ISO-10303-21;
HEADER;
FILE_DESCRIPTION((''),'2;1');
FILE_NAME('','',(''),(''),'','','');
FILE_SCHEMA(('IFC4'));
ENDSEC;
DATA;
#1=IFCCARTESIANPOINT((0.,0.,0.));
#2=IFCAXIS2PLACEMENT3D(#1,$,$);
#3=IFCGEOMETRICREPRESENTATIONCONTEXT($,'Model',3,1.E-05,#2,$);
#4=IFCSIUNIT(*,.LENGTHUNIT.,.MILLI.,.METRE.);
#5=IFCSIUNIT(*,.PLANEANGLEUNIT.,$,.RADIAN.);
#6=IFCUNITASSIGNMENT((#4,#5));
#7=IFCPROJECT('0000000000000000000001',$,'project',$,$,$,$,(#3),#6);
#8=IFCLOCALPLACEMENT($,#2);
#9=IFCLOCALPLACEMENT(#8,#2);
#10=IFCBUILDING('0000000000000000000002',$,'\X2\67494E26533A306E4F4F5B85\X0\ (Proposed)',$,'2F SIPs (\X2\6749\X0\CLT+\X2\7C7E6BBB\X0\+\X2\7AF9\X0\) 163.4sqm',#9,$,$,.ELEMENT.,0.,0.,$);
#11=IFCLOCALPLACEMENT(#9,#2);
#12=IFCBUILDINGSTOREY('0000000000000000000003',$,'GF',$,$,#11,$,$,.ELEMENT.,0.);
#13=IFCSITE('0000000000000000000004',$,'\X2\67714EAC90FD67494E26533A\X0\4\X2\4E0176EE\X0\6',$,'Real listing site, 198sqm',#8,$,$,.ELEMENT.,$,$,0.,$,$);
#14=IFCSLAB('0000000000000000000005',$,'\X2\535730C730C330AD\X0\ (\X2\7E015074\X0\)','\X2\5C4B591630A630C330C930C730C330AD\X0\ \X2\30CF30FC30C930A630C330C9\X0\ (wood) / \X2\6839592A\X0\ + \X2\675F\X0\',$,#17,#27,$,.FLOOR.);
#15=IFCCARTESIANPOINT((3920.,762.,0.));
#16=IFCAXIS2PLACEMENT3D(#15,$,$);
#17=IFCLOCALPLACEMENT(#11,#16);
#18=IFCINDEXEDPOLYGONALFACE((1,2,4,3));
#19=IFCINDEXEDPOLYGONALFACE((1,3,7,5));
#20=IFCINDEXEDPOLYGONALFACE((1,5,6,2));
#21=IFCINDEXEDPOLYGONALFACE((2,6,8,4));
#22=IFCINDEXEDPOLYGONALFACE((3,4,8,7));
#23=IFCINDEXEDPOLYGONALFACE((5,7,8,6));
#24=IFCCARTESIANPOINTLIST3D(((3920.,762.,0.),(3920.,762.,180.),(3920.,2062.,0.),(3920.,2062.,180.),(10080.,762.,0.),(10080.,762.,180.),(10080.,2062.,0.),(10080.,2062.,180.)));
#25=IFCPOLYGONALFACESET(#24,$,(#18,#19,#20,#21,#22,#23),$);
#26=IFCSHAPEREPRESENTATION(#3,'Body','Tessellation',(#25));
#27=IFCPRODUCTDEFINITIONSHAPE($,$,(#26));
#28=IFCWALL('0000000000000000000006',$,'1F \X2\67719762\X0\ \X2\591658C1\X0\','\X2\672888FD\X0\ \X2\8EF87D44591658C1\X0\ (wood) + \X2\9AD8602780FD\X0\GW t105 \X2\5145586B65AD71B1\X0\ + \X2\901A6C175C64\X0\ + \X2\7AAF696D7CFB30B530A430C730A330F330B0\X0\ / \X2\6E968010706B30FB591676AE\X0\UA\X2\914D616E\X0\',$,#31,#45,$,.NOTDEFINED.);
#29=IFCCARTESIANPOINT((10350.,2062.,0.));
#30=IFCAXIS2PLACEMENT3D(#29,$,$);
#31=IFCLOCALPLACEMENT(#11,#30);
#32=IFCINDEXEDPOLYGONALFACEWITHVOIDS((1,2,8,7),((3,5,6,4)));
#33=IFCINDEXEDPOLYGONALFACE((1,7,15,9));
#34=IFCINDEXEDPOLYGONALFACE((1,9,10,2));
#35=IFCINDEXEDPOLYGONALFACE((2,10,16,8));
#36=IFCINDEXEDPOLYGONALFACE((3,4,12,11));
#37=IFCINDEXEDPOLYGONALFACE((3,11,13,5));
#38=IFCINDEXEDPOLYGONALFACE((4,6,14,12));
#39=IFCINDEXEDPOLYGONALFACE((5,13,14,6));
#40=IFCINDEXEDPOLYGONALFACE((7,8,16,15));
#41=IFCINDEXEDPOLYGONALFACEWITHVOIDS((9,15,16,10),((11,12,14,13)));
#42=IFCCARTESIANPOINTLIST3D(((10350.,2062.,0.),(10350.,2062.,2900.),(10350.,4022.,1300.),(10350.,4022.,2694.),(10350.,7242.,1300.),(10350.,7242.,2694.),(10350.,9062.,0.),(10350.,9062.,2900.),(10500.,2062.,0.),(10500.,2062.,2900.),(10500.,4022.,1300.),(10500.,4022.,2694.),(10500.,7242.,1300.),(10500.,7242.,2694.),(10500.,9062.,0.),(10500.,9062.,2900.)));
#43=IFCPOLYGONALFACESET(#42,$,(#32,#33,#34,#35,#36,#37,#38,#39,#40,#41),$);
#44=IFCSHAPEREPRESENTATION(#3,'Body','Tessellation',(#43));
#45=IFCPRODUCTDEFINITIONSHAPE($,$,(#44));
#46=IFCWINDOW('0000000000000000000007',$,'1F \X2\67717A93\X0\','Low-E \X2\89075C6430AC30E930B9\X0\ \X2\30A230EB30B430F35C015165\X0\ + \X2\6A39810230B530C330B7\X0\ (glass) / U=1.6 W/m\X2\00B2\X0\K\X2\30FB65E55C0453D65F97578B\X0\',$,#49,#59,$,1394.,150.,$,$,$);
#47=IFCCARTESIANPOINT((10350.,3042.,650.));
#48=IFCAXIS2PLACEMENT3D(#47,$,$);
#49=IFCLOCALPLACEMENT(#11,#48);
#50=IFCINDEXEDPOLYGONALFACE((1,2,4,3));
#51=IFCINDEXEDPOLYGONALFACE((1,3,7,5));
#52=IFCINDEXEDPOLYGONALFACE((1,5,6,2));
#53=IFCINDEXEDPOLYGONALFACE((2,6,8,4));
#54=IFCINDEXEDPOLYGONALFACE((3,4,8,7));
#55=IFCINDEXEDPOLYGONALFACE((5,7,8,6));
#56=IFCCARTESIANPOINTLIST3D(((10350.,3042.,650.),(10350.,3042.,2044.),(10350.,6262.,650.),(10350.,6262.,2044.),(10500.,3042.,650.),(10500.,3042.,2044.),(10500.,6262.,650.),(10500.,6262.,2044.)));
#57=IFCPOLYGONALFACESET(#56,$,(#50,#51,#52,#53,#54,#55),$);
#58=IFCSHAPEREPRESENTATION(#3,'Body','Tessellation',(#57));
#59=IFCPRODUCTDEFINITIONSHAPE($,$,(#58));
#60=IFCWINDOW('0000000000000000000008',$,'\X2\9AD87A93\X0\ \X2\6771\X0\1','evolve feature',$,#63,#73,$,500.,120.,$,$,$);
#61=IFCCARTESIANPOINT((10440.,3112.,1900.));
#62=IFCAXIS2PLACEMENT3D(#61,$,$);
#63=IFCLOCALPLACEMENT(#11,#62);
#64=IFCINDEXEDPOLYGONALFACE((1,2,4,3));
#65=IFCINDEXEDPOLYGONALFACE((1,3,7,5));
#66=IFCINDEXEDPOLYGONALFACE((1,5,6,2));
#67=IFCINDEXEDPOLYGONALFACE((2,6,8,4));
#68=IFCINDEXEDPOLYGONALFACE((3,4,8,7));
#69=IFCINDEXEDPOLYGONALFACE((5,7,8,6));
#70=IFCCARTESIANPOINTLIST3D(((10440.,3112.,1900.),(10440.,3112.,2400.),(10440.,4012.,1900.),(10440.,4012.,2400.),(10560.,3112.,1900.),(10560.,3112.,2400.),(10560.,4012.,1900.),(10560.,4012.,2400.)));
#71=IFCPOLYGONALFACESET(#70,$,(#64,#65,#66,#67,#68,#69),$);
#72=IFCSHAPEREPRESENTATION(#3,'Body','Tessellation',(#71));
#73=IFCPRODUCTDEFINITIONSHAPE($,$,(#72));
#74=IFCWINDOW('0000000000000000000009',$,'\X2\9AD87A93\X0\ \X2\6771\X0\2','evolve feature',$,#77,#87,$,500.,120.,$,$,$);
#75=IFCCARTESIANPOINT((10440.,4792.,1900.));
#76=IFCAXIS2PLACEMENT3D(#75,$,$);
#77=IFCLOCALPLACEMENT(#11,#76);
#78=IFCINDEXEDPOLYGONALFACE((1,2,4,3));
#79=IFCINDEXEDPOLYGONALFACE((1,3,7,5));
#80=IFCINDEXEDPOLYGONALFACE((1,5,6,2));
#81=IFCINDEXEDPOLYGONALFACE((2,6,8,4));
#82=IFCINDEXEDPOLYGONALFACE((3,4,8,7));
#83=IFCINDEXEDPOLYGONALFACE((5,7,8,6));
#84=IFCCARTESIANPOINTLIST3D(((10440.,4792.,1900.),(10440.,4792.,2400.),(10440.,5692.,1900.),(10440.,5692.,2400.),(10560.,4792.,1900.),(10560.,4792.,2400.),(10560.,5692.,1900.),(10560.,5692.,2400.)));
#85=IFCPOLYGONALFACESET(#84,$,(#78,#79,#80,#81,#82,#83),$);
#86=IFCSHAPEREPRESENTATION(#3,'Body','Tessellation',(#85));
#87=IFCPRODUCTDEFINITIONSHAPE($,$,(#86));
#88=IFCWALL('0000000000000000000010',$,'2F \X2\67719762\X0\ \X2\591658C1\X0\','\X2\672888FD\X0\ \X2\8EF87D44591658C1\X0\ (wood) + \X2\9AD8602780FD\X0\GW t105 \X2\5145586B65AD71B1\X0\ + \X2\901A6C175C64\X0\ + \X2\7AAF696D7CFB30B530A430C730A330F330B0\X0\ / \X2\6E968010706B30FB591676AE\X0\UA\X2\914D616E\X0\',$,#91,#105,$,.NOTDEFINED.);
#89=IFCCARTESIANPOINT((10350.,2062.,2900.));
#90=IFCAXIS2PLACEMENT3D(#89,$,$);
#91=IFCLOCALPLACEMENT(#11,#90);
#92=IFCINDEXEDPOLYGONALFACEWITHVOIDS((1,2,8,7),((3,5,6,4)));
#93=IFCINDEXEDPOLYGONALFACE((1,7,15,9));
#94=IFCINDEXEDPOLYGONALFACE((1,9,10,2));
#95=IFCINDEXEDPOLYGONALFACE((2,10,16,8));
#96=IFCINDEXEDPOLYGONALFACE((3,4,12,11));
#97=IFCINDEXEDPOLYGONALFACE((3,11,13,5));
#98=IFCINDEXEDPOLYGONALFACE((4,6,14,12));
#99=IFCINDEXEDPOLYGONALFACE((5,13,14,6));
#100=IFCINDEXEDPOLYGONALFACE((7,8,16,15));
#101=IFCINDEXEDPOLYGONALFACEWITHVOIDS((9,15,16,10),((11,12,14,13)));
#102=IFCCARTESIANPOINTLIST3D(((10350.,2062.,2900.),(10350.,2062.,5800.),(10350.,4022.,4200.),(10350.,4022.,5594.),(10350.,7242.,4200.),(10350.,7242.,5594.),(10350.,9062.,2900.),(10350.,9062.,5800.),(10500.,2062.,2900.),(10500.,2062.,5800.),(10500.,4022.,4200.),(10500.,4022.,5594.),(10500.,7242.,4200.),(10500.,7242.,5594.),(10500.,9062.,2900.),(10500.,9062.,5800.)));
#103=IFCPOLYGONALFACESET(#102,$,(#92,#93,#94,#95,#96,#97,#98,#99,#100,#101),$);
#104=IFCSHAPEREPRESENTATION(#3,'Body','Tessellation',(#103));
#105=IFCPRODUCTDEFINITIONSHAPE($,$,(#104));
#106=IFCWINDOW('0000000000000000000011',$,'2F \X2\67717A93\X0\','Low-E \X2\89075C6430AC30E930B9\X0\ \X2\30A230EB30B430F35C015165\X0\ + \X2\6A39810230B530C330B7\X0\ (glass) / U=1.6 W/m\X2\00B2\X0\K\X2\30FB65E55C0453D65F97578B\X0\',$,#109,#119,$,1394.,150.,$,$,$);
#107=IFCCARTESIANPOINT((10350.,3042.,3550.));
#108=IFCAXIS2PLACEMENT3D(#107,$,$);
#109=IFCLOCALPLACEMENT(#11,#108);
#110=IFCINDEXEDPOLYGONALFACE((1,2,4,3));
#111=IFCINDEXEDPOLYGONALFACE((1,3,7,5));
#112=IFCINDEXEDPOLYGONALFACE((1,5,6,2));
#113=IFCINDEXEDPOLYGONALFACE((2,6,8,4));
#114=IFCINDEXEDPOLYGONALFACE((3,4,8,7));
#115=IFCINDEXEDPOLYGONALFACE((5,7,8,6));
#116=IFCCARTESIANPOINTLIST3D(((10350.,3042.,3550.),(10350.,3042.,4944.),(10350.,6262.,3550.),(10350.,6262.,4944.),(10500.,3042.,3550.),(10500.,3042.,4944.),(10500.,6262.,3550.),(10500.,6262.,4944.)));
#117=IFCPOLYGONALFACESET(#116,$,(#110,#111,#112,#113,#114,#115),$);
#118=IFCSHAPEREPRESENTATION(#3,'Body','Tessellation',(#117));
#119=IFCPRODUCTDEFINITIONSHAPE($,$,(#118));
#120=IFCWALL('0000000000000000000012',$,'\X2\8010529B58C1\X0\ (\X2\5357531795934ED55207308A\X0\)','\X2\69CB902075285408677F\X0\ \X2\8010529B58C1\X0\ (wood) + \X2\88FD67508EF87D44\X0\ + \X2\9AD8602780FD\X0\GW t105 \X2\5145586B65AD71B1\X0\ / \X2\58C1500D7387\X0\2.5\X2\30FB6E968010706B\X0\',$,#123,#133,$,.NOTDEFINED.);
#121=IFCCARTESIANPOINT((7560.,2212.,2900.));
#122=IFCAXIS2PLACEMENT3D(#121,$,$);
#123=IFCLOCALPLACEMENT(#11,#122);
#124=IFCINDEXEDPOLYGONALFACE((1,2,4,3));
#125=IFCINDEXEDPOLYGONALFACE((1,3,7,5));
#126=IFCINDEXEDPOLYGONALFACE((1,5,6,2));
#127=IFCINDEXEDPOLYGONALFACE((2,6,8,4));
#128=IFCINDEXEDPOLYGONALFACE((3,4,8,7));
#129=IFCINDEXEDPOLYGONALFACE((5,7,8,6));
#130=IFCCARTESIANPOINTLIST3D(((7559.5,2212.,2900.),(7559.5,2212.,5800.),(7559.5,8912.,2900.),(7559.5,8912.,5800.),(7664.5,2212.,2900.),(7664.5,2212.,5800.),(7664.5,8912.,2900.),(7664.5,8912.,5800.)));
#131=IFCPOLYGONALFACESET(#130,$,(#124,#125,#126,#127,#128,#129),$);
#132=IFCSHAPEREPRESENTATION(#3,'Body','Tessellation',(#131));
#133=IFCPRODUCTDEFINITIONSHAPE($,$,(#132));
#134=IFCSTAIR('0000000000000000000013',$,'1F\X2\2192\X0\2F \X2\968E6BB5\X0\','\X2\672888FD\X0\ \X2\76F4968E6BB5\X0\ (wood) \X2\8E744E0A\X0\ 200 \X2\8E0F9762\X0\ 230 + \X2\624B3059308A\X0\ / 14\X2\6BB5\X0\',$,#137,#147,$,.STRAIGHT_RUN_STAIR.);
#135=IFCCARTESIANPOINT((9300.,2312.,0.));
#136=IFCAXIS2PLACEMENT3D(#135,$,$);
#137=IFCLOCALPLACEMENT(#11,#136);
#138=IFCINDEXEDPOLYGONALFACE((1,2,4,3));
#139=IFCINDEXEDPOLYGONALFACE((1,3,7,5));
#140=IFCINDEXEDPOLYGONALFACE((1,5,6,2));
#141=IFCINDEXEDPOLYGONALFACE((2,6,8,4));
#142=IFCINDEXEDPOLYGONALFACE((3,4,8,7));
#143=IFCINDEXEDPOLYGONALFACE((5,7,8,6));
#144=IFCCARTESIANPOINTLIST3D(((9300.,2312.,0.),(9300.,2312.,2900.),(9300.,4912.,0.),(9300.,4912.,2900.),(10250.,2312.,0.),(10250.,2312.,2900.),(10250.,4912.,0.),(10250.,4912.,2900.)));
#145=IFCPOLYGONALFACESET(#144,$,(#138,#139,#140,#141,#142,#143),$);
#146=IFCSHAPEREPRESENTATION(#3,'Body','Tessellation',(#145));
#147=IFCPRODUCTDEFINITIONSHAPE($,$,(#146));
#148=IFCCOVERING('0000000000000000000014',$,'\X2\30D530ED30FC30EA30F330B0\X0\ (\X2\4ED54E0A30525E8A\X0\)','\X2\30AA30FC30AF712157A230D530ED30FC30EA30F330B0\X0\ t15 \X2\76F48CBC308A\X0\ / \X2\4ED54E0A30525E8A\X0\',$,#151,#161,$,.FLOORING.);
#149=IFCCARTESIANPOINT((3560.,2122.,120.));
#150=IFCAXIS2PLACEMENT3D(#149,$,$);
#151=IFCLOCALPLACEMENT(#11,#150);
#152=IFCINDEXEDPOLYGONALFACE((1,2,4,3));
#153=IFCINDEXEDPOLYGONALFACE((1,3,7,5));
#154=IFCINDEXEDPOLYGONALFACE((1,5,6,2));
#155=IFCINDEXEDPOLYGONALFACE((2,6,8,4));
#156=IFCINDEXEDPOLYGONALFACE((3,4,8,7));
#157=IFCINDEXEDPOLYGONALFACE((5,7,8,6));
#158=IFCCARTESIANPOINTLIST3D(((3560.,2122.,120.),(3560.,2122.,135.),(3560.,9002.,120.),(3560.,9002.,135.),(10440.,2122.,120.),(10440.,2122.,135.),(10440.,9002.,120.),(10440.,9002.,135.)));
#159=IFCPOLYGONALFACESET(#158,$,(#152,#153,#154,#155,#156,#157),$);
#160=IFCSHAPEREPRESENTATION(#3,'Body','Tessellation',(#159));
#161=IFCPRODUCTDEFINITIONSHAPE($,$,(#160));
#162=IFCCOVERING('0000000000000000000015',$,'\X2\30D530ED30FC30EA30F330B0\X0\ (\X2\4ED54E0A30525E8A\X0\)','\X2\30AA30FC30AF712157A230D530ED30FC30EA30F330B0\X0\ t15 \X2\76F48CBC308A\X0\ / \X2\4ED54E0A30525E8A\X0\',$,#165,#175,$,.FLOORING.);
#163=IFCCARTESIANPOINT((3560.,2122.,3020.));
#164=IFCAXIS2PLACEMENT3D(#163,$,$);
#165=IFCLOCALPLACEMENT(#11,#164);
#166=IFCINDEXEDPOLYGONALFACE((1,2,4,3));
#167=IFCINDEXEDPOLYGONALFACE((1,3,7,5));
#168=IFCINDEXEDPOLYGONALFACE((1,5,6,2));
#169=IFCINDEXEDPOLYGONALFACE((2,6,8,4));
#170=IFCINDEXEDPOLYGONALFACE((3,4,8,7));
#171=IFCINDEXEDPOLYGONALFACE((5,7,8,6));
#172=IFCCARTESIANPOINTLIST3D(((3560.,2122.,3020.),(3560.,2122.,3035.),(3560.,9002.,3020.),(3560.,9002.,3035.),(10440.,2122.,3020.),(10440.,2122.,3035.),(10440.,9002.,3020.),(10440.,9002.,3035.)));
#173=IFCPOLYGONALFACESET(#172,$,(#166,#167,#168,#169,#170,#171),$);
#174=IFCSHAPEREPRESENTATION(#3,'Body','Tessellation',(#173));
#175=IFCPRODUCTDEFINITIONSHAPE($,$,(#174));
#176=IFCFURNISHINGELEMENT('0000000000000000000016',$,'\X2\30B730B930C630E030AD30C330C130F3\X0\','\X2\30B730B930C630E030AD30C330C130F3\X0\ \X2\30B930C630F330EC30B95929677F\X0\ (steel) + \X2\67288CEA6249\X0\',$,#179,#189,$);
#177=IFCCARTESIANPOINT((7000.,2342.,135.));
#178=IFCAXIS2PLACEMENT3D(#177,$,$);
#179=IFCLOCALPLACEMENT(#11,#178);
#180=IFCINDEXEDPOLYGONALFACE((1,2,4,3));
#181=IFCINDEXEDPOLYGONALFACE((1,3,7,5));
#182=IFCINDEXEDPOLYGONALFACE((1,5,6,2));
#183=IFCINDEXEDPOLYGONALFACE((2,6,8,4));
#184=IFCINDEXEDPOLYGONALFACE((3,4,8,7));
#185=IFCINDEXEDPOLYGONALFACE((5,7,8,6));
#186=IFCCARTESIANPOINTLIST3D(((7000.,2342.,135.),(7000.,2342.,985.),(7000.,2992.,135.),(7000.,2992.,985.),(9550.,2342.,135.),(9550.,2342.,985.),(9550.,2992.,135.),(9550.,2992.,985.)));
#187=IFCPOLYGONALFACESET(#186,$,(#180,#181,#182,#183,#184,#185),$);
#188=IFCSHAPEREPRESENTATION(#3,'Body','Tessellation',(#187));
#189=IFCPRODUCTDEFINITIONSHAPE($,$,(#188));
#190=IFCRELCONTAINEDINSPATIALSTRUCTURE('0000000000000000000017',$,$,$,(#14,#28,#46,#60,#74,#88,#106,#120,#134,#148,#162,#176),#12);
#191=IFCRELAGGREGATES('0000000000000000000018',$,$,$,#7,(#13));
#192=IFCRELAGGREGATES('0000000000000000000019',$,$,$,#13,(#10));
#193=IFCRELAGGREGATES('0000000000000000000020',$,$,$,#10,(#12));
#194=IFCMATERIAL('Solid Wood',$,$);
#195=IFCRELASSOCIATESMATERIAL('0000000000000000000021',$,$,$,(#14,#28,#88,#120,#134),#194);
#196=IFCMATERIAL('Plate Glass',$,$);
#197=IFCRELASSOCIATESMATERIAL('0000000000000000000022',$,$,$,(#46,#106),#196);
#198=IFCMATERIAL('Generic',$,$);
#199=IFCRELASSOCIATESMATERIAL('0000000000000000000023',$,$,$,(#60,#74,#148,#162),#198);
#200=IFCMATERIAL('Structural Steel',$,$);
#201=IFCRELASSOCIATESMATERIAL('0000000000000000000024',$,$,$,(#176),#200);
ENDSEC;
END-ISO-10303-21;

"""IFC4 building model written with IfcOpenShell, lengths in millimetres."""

from ifc_helpers import new_model, si_unit, frame, frame_2d, origin, place, context, project, spatial, rectangle, extrude, material, element, fill, save


model = new_model("IFC4")

# Units and contexts
model_context = context("Model", 3, precision=1e-05, world=origin())
ifc_project = project(units=[si_unit("LENGTHUNIT", "METRE", prefix="MILLI"), si_unit("PLANEANGLEUNIT", "RADIAN")], contexts=[model_context])

# Site, building, storey
site_placement = place(None, origin())
site = spatial("IfcSite", under=ifc_project, at=site_placement, Name="東京都杉並区4丁目6", ObjectType="Real listing site, 198sqm", CompositionType="ELEMENT", RefElevation=0.0)
building_placement = place(site_placement, origin())
building = spatial("IfcBuilding", under=site, at=building_placement, Name="杉並区の住宅 (Proposed)", ObjectType="2F SIPs (杉CLT+籾殻+竹) 163.4sqm", CompositionType="ELEMENT", ElevationOfRefHeight=0.0, ElevationOfTerrain=0.0)
storey_placement = place(building_placement, origin())
storey = spatial("IfcBuildingStorey", under=building, at=storey_placement, Name="GF", CompositionType="ELEMENT", Elevation=0.0)

# Slab
ifc_material_1 = material(Name="Solid Wood")
slab_placement = place(storey_placement, frame((3920.0, 762.0, 0.0)))
element("IfcSlab", 1, at=slab_placement, inside=storey, material=ifc_material_1, Name="南デッキ (縁側)", Description="屋外ウッドデッキ ハードウッド (wood) / 根太 + 束", PredefinedType="FLOOR", context=model_context, shape_type="SweptSolid", body=[
    extrude(rectangle(XDim=6160.0, YDim=1300.0, at=frame_2d((3080.0, 650.0))), frame((3920.0, 762.0, 0.0)), (0.0, 0.0, 1.0), 180.0),
])

# Wall, openings, windows
wall_1_placement = place(storey_placement, frame((10350.0, 2062.0, 0.0)))
wall_1 = element("IfcWall", 2, at=wall_1_placement, inside=storey, material=ifc_material_1, Name="1F 東面 外壁", Description="木製 軸組外壁 (wood) + 高性能GW t105 充填断熱 + 通気層 + 窯業系サイディング / 準耐火・外皮UA配慮", PredefinedType="NOTDEFINED", context=model_context, shape_type="SweptSolid", body=[
    extrude(rectangle(XDim=150.0, YDim=7000.0, at=frame_2d((75.0, 3500.0))), frame((10350.0, 2062.0, 0.0)), (0.0, 0.0, 1.0), 2900.0),
])
opening_1_placement = place(storey_placement, frame((10350.0, 3042.0, 650.0)))
opening_1 = element("IfcOpeningElement", 3, at=opening_1_placement, cuts=wall_1, PredefinedType="NOTDEFINED", context=model_context, shape_type="SweptSolid", body=[
    extrude(rectangle(XDim=150.0, YDim=3220.0, at=frame_2d((75.0, 1610.0))), frame((10350.0, 3042.0, 650.0)), (0.0, 0.0, 1.0), 1394.0),
])
opening_2_placement = place(storey_placement, frame((10440.0, 3112.0, 1900.0)))
opening_2 = element("IfcOpeningElement", 4, at=opening_2_placement, cuts=wall_1, PredefinedType="NOTDEFINED", context=model_context, shape_type="SweptSolid", body=[
    extrude(rectangle(XDim=120.0, YDim=900.0, at=frame_2d((60.0, 450.0))), frame((10440.0, 3112.0, 1900.0)), (0.0, 0.0, 1.0), 500.0),
])
opening_3_placement = place(storey_placement, frame((10440.0, 4792.0, 1900.0)))
opening_3 = element("IfcOpeningElement", 5, at=opening_3_placement, cuts=wall_1, PredefinedType="NOTDEFINED", context=model_context, shape_type="SweptSolid", body=[
    extrude(rectangle(XDim=120.0, YDim=900.0, at=frame_2d((60.0, 450.0))), frame((10440.0, 4792.0, 1900.0)), (0.0, 0.0, 1.0), 500.0),
])
ifc_material_2 = material(Name="Plate Glass")
window_1_placement = place(storey_placement, frame((10350.0, 3042.0, 650.0)))
window_1 = element("IfcWindow", 6, at=window_1_placement, inside=storey, material=ifc_material_2, Name="1F 東窓", Description="Low-E 複層ガラス アルゴン封入 + 樹脂サッシ (glass) / U=1.6 W/m²K・日射取得型", OverallHeight=1394.0, OverallWidth=150.0, context=model_context, shape_type="SweptSolid", body=[
    extrude(rectangle(XDim=150.0, YDim=3220.0, at=frame_2d((75.0, 1610.0))), frame((10350.0, 3042.0, 650.0)), (0.0, 0.0, 1.0), 1394.0),
])
fill(opening_1, window_1)
ifc_material_3 = material(Name="Generic")
window_2_placement = place(storey_placement, frame((10440.0, 3112.0, 1900.0)))
window_2 = element("IfcWindow", 7, at=window_2_placement, inside=storey, material=ifc_material_3, Name="高窓 東1", Description="evolve feature", OverallHeight=500.0, OverallWidth=120.0, context=model_context, shape_type="SweptSolid", body=[
    extrude(rectangle(XDim=120.0, YDim=900.0, at=frame_2d((60.0, 450.0))), frame((10440.0, 3112.0, 1900.0)), (0.0, 0.0, 1.0), 500.0),
])
fill(opening_2, window_2)
window_3_placement = place(storey_placement, frame((10440.0, 4792.0, 1900.0)))
window_3 = element("IfcWindow", 8, at=window_3_placement, inside=storey, material=ifc_material_3, Name="高窓 東2", Description="evolve feature", OverallHeight=500.0, OverallWidth=120.0, context=model_context, shape_type="SweptSolid", body=[
    extrude(rectangle(XDim=120.0, YDim=900.0, at=frame_2d((60.0, 450.0))), frame((10440.0, 4792.0, 1900.0)), (0.0, 0.0, 1.0), 500.0),
])
fill(opening_3, window_3)

# Wall, opening, window
wall_2_placement = place(storey_placement, frame((10350.0, 2062.0, 2900.0)))
wall_2 = element("IfcWall", 9, at=wall_2_placement, inside=storey, material=ifc_material_1, Name="2F 東面 外壁", Description="木製 軸組外壁 (wood) + 高性能GW t105 充填断熱 + 通気層 + 窯業系サイディング / 準耐火・外皮UA配慮", PredefinedType="NOTDEFINED", context=model_context, shape_type="SweptSolid", body=[
    extrude(rectangle(XDim=150.0, YDim=7000.0, at=frame_2d((75.0, 3500.0))), frame((10350.0, 2062.0, 2900.0)), (0.0, 0.0, 1.0), 2900.0),
])
opening_4_placement = place(storey_placement, frame((10350.0, 3042.0, 3550.0)))
opening_4 = element("IfcOpeningElement", 10, at=opening_4_placement, cuts=wall_2, PredefinedType="NOTDEFINED", context=model_context, shape_type="SweptSolid", body=[
    extrude(rectangle(XDim=150.0, YDim=3220.0, at=frame_2d((75.0, 1610.0))), frame((10350.0, 3042.0, 3550.0)), (0.0, 0.0, 1.0), 1394.0),
])
window_4_placement = place(storey_placement, frame((10350.0, 3042.0, 3550.0)))
window_4 = element("IfcWindow", 11, at=window_4_placement, inside=storey, material=ifc_material_2, Name="2F 東窓", Description="Low-E 複層ガラス アルゴン封入 + 樹脂サッシ (glass) / U=1.6 W/m²K・日射取得型", OverallHeight=1394.0, OverallWidth=150.0, context=model_context, shape_type="SweptSolid", body=[
    extrude(rectangle(XDim=150.0, YDim=3220.0, at=frame_2d((75.0, 1610.0))), frame((10350.0, 3042.0, 3550.0)), (0.0, 0.0, 1.0), 1394.0),
])
fill(opening_4, window_4)

# Wall
wall_3_placement = place(storey_placement, frame((7560.0, 2212.0, 2900.0)))
element("IfcWall", 12, at=wall_3_placement, inside=storey, material=ifc_material_1, Name="耐力壁 (南北間仕切り)", Description="構造用合板 耐力壁 (wood) + 製材軸組 + 高性能GW t105 充填断熱 / 壁倍率2.5・準耐火", PredefinedType="NOTDEFINED", context=model_context, shape_type="SweptSolid", body=[
    extrude(rectangle(XDim=105.0, YDim=6700.0, at=frame_2d((52.0, 3350.0))), frame((7560.0, 2212.0, 2900.0)), (0.0, 0.0, 1.0), 2900.0),
])

# Stair
stair_placement = place(storey_placement, frame((9300.0, 2312.0, 0.0)))
element("IfcStair", 13, at=stair_placement, inside=storey, material=ifc_material_1, Name="1F→2F 階段", Description="木製 直階段 (wood) 蹴上 200 踏面 230 + 手すり / 14段", PredefinedType="STRAIGHT_RUN_STAIR", context=model_context, shape_type="SweptSolid", body=[
    extrude(rectangle(XDim=950.0, YDim=2600.0, at=frame_2d((475.0, 1300.0))), frame((9300.0, 2312.0, 0.0)), (0.0, 0.0, 1.0), 2900.0),
])

# Coverings
covering_1_placement = place(storey_placement, frame((3560.0, 2122.0, 120.0)))
element("IfcCovering", 14, at=covering_1_placement, inside=storey, material=ifc_material_3, Name="フローリング (仕上げ床)", Description="オーク無垢フローリング t15 直貼り / 仕上げ床", PredefinedType="FLOORING", context=model_context, shape_type="SweptSolid", body=[
    extrude(rectangle(XDim=6880.0, YDim=6880.0, at=frame_2d((3440.0, 3440.0))), frame((3560.0, 2122.0, 120.0)), (0.0, 0.0, 1.0), 15.0),
])
covering_2_placement = place(storey_placement, frame((3560.0, 2122.0, 3020.0)))
element("IfcCovering", 15, at=covering_2_placement, inside=storey, material=ifc_material_3, Name="フローリング (仕上げ床)", Description="オーク無垢フローリング t15 直貼り / 仕上げ床", PredefinedType="FLOORING", context=model_context, shape_type="SweptSolid", body=[
    extrude(rectangle(XDim=6880.0, YDim=6880.0, at=frame_2d((3440.0, 3440.0))), frame((3560.0, 2122.0, 3020.0)), (0.0, 0.0, 1.0), 15.0),
])

# Furnishing element
ifc_material_4 = material(Name="Structural Steel")
furnishing_1_placement = place(storey_placement, frame((7000.0, 2342.0, 135.0)))
element("IfcFurnishingElement", 16, at=furnishing_1_placement, inside=storey, material=ifc_material_4, Name="システムキッチン", Description="システムキッチン ステンレス天板 (steel) + 木質扉", context=model_context, shape_type="SweptSolid", body=[
    extrude(rectangle(XDim=2550.0, YDim=650.0, at=frame_2d((1275.0, 325.0))), frame((7000.0, 2342.0, 135.0)), (0.0, 0.0, 1.0), 850.0),
])

save(model, "model.ifc")
